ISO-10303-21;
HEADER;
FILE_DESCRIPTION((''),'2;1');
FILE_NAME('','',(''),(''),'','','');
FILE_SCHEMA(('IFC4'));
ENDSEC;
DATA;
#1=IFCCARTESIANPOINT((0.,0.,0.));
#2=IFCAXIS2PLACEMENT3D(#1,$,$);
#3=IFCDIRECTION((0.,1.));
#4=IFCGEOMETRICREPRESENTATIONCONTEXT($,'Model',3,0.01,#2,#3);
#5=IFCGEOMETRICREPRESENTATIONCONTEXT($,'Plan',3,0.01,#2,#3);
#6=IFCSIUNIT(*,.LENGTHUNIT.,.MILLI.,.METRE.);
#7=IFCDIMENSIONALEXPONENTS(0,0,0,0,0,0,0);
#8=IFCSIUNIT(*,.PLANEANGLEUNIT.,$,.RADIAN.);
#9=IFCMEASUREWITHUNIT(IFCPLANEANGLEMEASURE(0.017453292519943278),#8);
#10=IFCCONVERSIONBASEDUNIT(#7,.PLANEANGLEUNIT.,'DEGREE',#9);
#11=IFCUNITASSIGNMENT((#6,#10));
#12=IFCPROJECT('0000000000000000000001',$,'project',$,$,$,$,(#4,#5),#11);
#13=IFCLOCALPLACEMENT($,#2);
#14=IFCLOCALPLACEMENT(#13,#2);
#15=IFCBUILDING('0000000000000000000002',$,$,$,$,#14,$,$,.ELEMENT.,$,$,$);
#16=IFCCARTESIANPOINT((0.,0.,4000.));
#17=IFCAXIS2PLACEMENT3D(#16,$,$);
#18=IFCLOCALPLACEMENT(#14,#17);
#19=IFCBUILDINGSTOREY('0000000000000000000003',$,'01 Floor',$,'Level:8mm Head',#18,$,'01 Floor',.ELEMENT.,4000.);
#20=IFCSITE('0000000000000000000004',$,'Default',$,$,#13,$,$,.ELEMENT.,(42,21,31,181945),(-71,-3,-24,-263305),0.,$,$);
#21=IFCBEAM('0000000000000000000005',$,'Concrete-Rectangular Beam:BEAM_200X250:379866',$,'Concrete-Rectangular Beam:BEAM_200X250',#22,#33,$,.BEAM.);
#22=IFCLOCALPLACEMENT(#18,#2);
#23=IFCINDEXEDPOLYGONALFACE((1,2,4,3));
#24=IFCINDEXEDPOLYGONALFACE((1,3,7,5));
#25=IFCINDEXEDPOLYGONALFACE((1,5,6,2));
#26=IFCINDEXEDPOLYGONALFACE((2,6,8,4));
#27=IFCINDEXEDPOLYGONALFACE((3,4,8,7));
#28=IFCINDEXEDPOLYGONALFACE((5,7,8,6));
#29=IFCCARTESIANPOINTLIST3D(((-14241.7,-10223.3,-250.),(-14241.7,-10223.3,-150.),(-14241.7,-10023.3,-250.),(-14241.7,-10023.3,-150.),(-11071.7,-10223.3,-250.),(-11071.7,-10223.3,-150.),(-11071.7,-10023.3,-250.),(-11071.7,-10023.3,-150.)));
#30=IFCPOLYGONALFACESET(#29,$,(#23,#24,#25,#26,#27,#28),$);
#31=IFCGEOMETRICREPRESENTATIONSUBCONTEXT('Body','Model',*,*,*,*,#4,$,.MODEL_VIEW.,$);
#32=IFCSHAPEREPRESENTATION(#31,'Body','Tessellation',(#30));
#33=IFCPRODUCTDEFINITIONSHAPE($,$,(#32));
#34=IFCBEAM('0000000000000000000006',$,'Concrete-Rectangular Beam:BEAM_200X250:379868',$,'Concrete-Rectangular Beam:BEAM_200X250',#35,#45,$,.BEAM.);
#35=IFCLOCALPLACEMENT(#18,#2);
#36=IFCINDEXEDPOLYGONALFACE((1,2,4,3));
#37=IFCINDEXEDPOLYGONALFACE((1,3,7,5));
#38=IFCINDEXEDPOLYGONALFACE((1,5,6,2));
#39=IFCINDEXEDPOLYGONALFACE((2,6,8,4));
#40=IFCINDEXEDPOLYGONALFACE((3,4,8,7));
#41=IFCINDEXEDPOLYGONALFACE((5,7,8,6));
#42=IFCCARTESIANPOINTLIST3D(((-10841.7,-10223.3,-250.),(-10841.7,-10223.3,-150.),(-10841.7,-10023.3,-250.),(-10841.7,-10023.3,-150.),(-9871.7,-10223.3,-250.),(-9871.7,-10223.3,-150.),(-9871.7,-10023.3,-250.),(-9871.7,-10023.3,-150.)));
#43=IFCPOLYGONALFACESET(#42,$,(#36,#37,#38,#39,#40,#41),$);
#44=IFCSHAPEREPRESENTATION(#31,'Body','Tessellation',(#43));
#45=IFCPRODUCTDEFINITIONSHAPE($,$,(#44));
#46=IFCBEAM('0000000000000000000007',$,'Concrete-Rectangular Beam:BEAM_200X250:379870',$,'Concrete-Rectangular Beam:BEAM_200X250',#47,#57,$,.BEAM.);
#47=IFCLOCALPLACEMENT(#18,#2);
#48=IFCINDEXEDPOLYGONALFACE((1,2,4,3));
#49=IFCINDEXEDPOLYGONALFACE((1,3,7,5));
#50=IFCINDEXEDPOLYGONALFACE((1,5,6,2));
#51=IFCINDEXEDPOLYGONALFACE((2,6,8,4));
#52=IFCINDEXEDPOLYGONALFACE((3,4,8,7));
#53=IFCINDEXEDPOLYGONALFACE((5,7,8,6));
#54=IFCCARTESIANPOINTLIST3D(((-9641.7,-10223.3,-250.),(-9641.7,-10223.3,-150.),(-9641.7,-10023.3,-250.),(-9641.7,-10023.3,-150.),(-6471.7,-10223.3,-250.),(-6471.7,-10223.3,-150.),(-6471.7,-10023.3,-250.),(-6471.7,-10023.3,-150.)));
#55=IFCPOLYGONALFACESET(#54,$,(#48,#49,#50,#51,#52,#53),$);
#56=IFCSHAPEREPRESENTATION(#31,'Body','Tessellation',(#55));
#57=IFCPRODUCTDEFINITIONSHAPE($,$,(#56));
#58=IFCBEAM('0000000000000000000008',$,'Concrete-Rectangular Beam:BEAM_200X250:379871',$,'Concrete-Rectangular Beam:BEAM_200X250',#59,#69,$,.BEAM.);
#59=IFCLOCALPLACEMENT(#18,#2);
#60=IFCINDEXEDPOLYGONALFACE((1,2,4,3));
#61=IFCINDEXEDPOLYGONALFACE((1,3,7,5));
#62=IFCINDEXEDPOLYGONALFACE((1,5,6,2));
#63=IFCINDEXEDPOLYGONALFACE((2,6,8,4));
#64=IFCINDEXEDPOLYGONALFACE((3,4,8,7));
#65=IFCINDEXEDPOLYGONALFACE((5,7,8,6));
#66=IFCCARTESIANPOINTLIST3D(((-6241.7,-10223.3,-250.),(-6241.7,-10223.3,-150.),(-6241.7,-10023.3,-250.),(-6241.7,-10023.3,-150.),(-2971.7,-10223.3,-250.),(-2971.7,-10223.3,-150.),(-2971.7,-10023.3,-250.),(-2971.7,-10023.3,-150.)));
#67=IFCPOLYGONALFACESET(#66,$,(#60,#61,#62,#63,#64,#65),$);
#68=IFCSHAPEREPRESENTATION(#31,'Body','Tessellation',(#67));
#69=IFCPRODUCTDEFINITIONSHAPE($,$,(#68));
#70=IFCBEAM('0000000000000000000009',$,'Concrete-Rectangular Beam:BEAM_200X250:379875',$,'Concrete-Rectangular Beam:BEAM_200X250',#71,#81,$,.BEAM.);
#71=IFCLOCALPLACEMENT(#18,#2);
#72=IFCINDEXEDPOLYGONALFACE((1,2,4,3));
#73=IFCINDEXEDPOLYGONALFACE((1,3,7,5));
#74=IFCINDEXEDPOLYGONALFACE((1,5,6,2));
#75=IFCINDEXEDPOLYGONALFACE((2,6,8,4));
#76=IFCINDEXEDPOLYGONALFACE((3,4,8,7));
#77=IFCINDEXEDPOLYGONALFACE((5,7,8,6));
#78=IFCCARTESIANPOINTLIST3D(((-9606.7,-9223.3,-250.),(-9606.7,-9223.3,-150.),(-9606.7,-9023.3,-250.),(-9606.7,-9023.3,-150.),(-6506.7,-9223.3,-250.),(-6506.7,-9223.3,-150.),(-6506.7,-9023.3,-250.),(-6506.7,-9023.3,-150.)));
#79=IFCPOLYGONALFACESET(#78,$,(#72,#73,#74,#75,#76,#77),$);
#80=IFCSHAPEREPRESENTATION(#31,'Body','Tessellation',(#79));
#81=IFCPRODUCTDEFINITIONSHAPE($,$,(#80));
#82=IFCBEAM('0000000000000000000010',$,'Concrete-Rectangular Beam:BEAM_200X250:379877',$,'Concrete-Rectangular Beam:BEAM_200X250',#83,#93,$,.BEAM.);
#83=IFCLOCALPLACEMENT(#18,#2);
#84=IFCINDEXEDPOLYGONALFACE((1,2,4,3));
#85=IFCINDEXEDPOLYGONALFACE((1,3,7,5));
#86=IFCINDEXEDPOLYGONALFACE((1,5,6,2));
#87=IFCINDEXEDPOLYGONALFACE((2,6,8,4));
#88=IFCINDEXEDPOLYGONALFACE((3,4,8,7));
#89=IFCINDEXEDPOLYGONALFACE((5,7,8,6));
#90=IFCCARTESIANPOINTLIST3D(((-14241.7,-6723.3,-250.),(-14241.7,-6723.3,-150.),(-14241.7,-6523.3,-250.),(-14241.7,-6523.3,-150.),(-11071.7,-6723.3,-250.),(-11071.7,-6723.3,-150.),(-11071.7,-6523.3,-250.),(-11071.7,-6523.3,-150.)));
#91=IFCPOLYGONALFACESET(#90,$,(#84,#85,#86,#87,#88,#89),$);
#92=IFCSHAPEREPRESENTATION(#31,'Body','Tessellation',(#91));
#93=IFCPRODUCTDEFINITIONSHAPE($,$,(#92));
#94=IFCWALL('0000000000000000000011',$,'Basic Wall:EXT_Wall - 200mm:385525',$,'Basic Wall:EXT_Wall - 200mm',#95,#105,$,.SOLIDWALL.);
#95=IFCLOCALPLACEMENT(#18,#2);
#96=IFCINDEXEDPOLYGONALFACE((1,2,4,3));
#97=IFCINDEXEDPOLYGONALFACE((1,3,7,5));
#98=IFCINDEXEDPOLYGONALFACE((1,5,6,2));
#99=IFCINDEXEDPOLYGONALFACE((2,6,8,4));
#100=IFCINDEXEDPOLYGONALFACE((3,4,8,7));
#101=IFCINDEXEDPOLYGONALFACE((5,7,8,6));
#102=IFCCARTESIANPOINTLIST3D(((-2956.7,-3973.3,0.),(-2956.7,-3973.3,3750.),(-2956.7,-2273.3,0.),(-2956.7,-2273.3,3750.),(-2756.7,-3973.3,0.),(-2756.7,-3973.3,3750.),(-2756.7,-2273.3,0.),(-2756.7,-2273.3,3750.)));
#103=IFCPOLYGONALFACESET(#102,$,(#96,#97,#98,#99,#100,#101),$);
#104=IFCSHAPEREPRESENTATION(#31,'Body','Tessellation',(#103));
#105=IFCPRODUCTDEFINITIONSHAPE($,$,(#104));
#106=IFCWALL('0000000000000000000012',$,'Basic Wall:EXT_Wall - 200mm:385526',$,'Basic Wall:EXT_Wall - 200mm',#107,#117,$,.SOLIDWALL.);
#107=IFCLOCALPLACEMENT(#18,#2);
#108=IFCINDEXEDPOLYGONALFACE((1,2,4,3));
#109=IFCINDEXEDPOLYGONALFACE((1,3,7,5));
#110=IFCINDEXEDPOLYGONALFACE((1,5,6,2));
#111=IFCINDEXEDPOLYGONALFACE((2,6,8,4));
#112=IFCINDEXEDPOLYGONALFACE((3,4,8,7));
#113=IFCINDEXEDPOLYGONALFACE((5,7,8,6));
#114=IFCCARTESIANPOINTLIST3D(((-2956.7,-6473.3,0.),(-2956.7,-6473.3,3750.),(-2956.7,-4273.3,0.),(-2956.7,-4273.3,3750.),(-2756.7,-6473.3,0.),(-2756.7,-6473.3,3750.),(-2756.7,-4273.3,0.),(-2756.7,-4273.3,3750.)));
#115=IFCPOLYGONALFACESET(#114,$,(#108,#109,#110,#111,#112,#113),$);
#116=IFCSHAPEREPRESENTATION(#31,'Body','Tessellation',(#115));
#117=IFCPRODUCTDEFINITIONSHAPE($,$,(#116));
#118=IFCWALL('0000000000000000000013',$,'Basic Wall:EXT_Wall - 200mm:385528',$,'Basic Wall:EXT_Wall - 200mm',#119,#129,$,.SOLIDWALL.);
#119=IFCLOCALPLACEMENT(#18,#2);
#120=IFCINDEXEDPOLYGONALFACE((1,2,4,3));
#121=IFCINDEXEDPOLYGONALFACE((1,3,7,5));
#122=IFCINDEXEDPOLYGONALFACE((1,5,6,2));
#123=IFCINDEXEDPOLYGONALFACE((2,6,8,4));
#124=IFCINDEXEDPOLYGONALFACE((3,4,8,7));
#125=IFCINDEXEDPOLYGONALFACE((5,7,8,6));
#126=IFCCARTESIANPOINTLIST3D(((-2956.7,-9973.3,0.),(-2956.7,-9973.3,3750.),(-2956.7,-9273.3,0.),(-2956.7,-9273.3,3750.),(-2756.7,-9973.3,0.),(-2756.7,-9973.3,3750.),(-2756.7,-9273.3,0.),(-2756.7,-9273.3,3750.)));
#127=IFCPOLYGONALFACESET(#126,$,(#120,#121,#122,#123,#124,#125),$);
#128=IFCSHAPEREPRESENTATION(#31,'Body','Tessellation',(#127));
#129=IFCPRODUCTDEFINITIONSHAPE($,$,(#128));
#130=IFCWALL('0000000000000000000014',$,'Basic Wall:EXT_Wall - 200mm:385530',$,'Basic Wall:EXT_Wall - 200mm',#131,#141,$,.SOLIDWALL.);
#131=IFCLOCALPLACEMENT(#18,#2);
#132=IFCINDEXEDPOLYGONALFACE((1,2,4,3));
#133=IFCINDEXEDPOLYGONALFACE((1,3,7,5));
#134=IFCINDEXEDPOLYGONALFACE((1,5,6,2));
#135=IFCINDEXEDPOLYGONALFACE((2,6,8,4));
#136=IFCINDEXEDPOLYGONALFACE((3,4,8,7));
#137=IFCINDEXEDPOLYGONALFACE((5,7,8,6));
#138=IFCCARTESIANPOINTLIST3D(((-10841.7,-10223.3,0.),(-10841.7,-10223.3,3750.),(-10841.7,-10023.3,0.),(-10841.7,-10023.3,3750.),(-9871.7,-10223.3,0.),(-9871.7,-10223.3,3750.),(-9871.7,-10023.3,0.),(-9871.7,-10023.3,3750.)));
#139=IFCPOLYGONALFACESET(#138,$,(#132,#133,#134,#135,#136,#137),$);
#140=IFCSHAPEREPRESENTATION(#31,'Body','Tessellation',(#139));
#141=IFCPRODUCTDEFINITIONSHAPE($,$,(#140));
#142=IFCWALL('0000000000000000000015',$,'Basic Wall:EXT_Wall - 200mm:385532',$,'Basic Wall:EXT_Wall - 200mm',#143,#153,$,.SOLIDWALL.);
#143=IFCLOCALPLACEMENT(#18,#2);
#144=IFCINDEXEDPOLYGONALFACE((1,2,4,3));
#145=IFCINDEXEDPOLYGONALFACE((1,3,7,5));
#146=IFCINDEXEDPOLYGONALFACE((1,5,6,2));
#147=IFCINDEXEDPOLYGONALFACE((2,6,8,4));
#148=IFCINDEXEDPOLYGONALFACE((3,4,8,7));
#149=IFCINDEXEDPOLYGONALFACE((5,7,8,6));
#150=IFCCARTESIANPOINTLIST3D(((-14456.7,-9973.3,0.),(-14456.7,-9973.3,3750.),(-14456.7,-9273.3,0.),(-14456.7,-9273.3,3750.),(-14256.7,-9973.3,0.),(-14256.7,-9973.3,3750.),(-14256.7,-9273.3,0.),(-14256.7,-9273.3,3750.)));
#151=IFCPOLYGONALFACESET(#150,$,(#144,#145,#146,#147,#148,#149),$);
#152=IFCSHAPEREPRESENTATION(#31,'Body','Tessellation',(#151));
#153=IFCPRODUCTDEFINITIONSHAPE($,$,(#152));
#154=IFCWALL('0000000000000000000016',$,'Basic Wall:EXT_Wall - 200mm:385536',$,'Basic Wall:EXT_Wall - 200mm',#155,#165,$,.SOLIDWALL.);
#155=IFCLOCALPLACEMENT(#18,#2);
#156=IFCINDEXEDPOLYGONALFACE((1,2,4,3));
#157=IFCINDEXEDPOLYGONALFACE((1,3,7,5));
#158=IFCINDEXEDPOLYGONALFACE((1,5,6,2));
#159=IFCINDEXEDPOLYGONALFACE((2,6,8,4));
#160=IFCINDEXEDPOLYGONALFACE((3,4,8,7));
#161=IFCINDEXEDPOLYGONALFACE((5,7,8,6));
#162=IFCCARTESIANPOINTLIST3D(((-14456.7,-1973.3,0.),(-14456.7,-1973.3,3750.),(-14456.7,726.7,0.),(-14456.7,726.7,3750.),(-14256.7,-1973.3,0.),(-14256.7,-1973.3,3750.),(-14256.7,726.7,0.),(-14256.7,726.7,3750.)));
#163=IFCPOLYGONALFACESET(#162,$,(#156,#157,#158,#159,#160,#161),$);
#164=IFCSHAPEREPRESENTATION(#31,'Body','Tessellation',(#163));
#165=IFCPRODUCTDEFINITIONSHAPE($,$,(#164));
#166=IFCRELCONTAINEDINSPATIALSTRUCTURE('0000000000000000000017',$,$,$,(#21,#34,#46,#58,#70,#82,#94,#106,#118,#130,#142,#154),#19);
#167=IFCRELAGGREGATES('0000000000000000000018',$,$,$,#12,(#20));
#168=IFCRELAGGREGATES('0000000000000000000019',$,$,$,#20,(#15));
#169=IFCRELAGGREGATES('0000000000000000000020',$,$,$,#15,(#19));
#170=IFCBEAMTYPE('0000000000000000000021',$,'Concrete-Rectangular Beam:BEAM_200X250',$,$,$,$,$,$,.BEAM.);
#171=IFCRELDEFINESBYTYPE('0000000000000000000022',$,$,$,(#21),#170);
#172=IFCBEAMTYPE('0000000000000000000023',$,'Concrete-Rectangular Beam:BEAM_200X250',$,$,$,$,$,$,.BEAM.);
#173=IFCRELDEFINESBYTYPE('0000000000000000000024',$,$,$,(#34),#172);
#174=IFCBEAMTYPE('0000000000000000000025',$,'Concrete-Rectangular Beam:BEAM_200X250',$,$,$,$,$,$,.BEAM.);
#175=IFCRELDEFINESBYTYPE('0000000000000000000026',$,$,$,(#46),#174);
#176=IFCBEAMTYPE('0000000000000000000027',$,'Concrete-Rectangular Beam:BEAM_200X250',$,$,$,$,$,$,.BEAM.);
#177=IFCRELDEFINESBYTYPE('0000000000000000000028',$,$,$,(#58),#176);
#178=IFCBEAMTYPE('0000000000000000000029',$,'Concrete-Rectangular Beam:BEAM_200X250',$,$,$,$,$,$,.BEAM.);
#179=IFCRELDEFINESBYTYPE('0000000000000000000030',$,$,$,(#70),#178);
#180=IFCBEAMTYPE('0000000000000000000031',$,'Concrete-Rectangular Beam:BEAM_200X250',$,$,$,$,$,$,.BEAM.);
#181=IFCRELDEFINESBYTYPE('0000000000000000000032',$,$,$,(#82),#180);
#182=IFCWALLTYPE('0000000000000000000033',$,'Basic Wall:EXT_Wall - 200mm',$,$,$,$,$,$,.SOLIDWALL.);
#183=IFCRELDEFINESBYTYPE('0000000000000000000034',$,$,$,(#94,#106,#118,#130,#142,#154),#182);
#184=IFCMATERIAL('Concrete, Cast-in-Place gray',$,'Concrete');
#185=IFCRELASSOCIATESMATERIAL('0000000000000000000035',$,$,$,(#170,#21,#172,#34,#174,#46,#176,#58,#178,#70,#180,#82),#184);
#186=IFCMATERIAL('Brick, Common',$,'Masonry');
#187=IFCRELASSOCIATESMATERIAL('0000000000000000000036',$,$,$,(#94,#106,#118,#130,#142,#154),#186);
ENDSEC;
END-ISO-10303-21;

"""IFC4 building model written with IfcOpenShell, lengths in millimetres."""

from ifc_helpers import new_model, entity, si_unit, converted_unit, direction, frame, origin, place, context, subcontext, project, spatial, indexed_curve, outline, extrude, source, transform, mapped, material, type_object, type_shapes, element, save


model = new_model("IFC4")

# Units and contexts
model_context = context("Model", 3, precision=0.01, world=origin(), true_north=direction((0.0, 1.0)))
plan_context = context("Plan", 3, precision=0.01, world=origin(), true_north=direction((0.0, 1.0)))
body_context = subcontext(model_context, "Body", "Model", "MODEL_VIEW")
ifc_project = project(units=[si_unit("LENGTHUNIT", "METRE", prefix="MILLI"), converted_unit("PLANEANGLEUNIT", "DEGREE", entity("IfcPlaneAngleMeasure", 0.017453292519943278), si_unit("PLANEANGLEUNIT", "RADIAN"), dimensions=[0, 0, 0, 0, 0, 0, 0])], contexts=[model_context, plan_context])

# Site, building, storey
site_placement = place(None, origin())
site = spatial("IfcSite", under=ifc_project, at=site_placement, Name="Default", CompositionType="ELEMENT", RefLatitude=(42, 21, 31, 181945), RefLongitude=(-71, -3, -24, -263305), RefElevation=0.0)
building_placement = place(site_placement, origin())
building = spatial("IfcBuilding", under=site, at=building_placement, CompositionType="ELEMENT")
storey_placement = place(building_placement, frame((0.0, 0.0, 4000.0)))
storey = spatial("IfcBuildingStorey", under=building, at=storey_placement, Name="01 Floor", ObjectType="Level:8mm Head", LongName="01 Floor", CompositionType="ELEMENT", Elevation=4000.0)

# Beams
ifc_material_1 = material(Name="Concrete, Cast-in-Place gray", Category="Concrete")
beam_type_1 = type_object("IfcBeamType", Name="Concrete-Rectangular Beam:BEAM_200X250", PredefinedType="BEAM", material=ifc_material_1)
shared_shape_1 = source(origin(), body_context, "Body", "SweptSolid", [
    extrude(outline(indexed_curve([(-50.0, -100.0), (50.0, -100.0), (50.0, 100.0), (-50.0, 100.0), (-50.0, -100.0)], self_intersect=False)), frame((-14241.7, -10123.3, 3800.0), z_axis=(1.0, 0.0, 0.0), x_axis=(0.0, 0.0, -1.0)), (0.0, 0.0, 1.0), 3170.0),
])
type_shapes(beam_type_1, [shared_shape_1])
beam_1_placement = place(storey_placement, frame((0.0, 0.0, -4000.0)))
element("IfcBeam", 1, at=beam_1_placement, inside=storey, type_object=beam_type_1, material=ifc_material_1, Name="Concrete-Rectangular Beam:BEAM_200X250:379866", ObjectType="Concrete-Rectangular Beam:BEAM_200X250", PredefinedType="BEAM", context=body_context, shape_type="MappedRepresentation", body=[
    mapped(shared_shape_1, transform((0.0, 0.0, 0.0), scale=1.0)),
])
beam_type_2 = type_object("IfcBeamType", Name="Concrete-Rectangular Beam:BEAM_200X250", PredefinedType="BEAM", material=ifc_material_1)
shared_shape_2 = source(origin(), body_context, "Body", "SweptSolid", [
    extrude(outline(indexed_curve([(-50.0, -100.0), (50.0, -100.0), (50.0, 100.0), (-50.0, 100.0), (-50.0, -100.0)], self_intersect=False)), frame((-10841.7, -10123.3, 3800.0), z_axis=(1.0, 0.0, 0.0), x_axis=(0.0, 0.0, -1.0)), (0.0, 0.0, 1.0), 970.0),
])
type_shapes(beam_type_2, [shared_shape_2])
beam_2_placement = place(storey_placement, frame((0.0, 0.0, -4000.0)))
element("IfcBeam", 2, at=beam_2_placement, inside=storey, type_object=beam_type_2, material=ifc_material_1, Name="Concrete-Rectangular Beam:BEAM_200X250:379868", ObjectType="Concrete-Rectangular Beam:BEAM_200X250", PredefinedType="BEAM", context=body_context, shape_type="MappedRepresentation", body=[
    mapped(shared_shape_2, transform((0.0, 0.0, 0.0), scale=1.0)),
])
beam_type_3 = type_object("IfcBeamType", Name="Concrete-Rectangular Beam:BEAM_200X250", PredefinedType="BEAM", material=ifc_material_1)
shared_shape_3 = source(origin(), body_context, "Body", "SweptSolid", [
    extrude(outline(indexed_curve([(-50.0, -100.0), (50.0, -100.0), (50.0, 100.0), (-50.0, 100.0), (-50.0, -100.0)], self_intersect=False)), frame((-9641.7, -10123.3, 3800.0), z_axis=(1.0, 0.0, 0.0), x_axis=(0.0, 0.0, -1.0)), (0.0, 0.0, 1.0), 3170.0),
])
type_shapes(beam_type_3, [shared_shape_3])
beam_3_placement = place(storey_placement, frame((0.0, 0.0, -4000.0)))
element("IfcBeam", 3, at=beam_3_placement, inside=storey, type_object=beam_type_3, material=ifc_material_1, Name="Concrete-Rectangular Beam:BEAM_200X250:379870", ObjectType="Concrete-Rectangular Beam:BEAM_200X250", PredefinedType="BEAM", context=body_context, shape_type="MappedRepresentation", body=[
    mapped(shared_shape_3, transform((0.0, 0.0, 0.0), scale=1.0)),
])
beam_type_4 = type_object("IfcBeamType", Name="Concrete-Rectangular Beam:BEAM_200X250", PredefinedType="BEAM", material=ifc_material_1)
shared_shape_4 = source(origin(), body_context, "Body", "SweptSolid", [
    extrude(outline(indexed_curve([(-50.0, -100.0), (50.0, -100.0), (50.0, 100.0), (-50.0, 100.0), (-50.0, -100.0)], self_intersect=False)), frame((-6241.7, -10123.3, 3800.0), z_axis=(1.0, 0.0, 0.0), x_axis=(0.0, 0.0, -1.0)), (0.0, 0.0, 1.0), 3270.0),
])
type_shapes(beam_type_4, [shared_shape_4])
beam_4_placement = place(storey_placement, frame((0.0, 0.0, -4000.0)))
element("IfcBeam", 4, at=beam_4_placement, inside=storey, type_object=beam_type_4, material=ifc_material_1, Name="Concrete-Rectangular Beam:BEAM_200X250:379871", ObjectType="Concrete-Rectangular Beam:BEAM_200X250", PredefinedType="BEAM", context=body_context, shape_type="MappedRepresentation", body=[
    mapped(shared_shape_4, transform((0.0, 0.0, 0.0), scale=1.0)),
])
beam_type_5 = type_object("IfcBeamType", Name="Concrete-Rectangular Beam:BEAM_200X250", PredefinedType="BEAM", material=ifc_material_1)
shared_shape_5 = source(origin(), body_context, "Body", "SweptSolid", [
    extrude(outline(indexed_curve([(-50.0, -100.0), (50.0, -100.0), (50.0, 100.0), (-50.0, 100.0), (-50.0, -100.0)], self_intersect=False)), frame((-9606.7, -9123.3, 3800.0), z_axis=(1.0, 0.0, 0.0), x_axis=(0.0, 0.0, -1.0)), (0.0, 0.0, 1.0), 3100.0),
])
type_shapes(beam_type_5, [shared_shape_5])
beam_5_placement = place(storey_placement, frame((0.0, 0.0, -4000.0)))
element("IfcBeam", 5, at=beam_5_placement, inside=storey, type_object=beam_type_5, material=ifc_material_1, Name="Concrete-Rectangular Beam:BEAM_200X250:379875", ObjectType="Concrete-Rectangular Beam:BEAM_200X250", PredefinedType="BEAM", context=body_context, shape_type="MappedRepresentation", body=[
    mapped(shared_shape_5, transform((0.0, 0.0, 0.0), scale=1.0)),
])
beam_type_6 = type_object("IfcBeamType", Name="Concrete-Rectangular Beam:BEAM_200X250", PredefinedType="BEAM", material=ifc_material_1)
shared_shape_6 = source(origin(), body_context, "Body", "SweptSolid", [
    extrude(outline(indexed_curve([(-50.0, -100.0), (50.0, -100.0), (50.0, 100.0), (-50.0, 100.0), (-50.0, -100.0)], self_intersect=False)), frame((-14241.7, -6623.3, 3800.0), z_axis=(1.0, 0.0, 0.0), x_axis=(0.0, 0.0, -1.0)), (0.0, 0.0, 1.0), 3170.0),
])
type_shapes(beam_type_6, [shared_shape_6])
beam_6_placement = place(storey_placement, frame((0.0, 0.0, -4000.0)))
element("IfcBeam", 6, at=beam_6_placement, inside=storey, type_object=beam_type_6, material=ifc_material_1, Name="Concrete-Rectangular Beam:BEAM_200X250:379877", ObjectType="Concrete-Rectangular Beam:BEAM_200X250", PredefinedType="BEAM", context=body_context, shape_type="MappedRepresentation", body=[
    mapped(shared_shape_6, transform((0.0, 0.0, 0.0), scale=1.0)),
])

# Walls
ifc_material_2 = material(Name="Brick, Common", Category="Masonry")
wall_type_1 = type_object("IfcWallType", Name="Basic Wall:EXT_Wall - 200mm", PredefinedType="SOLIDWALL")
wall_1_placement = place(storey_placement, frame((-2856.7, -2273.3, 0.0), z_axis=(0.0, 0.0, 1.0), x_axis=(0.0, -1.0, 0.0)))
element("IfcWall", 7, at=wall_1_placement, inside=storey, type_object=wall_type_1, material=ifc_material_2, Name="Basic Wall:EXT_Wall - 200mm:385525", ObjectType="Basic Wall:EXT_Wall - 200mm", PredefinedType="SOLIDWALL", context=body_context, shape_type="SweptSolid", body=[
    extrude(outline(indexed_curve([(1700.0, 100.0), (0.0, 100.0), (0.0, -100.0), (1700.0, -100.0), (1700.0, 100.0)], self_intersect=False)), origin(), (0.0, 0.0, 1.0), 3750.0),
])
wall_2_placement = place(storey_placement, frame((-2856.7, -4273.3, 0.0), z_axis=(0.0, 0.0, 1.0), x_axis=(0.0, -1.0, 0.0)))
element("IfcWall", 8, at=wall_2_placement, inside=storey, type_object=wall_type_1, material=ifc_material_2, Name="Basic Wall:EXT_Wall - 200mm:385526", ObjectType="Basic Wall:EXT_Wall - 200mm", PredefinedType="SOLIDWALL", context=body_context, shape_type="SweptSolid", body=[
    extrude(outline(indexed_curve([(2200.0, 100.0), (0.0, 100.0), (0.0, -100.0), (2200.0, -100.0), (2200.0, 100.0)], self_intersect=False)), origin(), (0.0, 0.0, 1.0), 3750.0),
])
wall_3_placement = place(storey_placement, frame((-2856.7, -9273.3, 0.0), z_axis=(0.0, 0.0, 1.0), x_axis=(0.0, -1.0, 0.0)))
element("IfcWall", 9, at=wall_3_placement, inside=storey, type_object=wall_type_1, material=ifc_material_2, Name="Basic Wall:EXT_Wall - 200mm:385528", ObjectType="Basic Wall:EXT_Wall - 200mm", PredefinedType="SOLIDWALL", context=body_context, shape_type="SweptSolid", body=[
    extrude(outline(indexed_curve([(700.0, 100.0), (0.0, 100.0), (0.0, -100.0), (700.0, -100.0), (700.0, 100.0)], self_intersect=False)), origin(), (0.0, 0.0, 1.0), 3750.0),
])
wall_4_placement = place(storey_placement, frame((-9871.7, -10123.3, 0.0), z_axis=(0.0, 0.0, 1.0), x_axis=(-1.0, 0.0, 0.0)))
element("IfcWall", 10, at=wall_4_placement, inside=storey, type_object=wall_type_1, material=ifc_material_2, Name="Basic Wall:EXT_Wall - 200mm:385530", ObjectType="Basic Wall:EXT_Wall - 200mm", PredefinedType="SOLIDWALL", context=body_context, shape_type="SweptSolid", body=[
    extrude(outline(indexed_curve([(970.0, 100.0), (0.0, 100.0), (0.0, -100.0), (970.0, -100.0), (970.0, 100.0)], self_intersect=False)), origin(), (0.0, 0.0, 1.0), 3750.0),
])
wall_5_placement = place(storey_placement, frame((-14356.7, -9973.3, 0.0), z_axis=(0.0, 0.0, 1.0), x_axis=(0.0, 1.0, 0.0)))
element("IfcWall", 11, at=wall_5_placement, inside=storey, type_object=wall_type_1, material=ifc_material_2, Name="Basic Wall:EXT_Wall - 200mm:385532", ObjectType="Basic Wall:EXT_Wall - 200mm", PredefinedType="SOLIDWALL", context=body_context, shape_type="SweptSolid", body=[
    extrude(outline(indexed_curve([(700.0, 100.0), (0.0, 100.0), (0.0, -100.0), (700.0, -100.0), (700.0, 100.0)], self_intersect=False)), origin(), (0.0, 0.0, 1.0), 3750.0),
])
wall_6_placement = place(storey_placement, frame((-14356.7, -1973.3, 0.0), z_axis=(0.0, 0.0, 1.0), x_axis=(0.0, 1.0, 0.0)))
element("IfcWall", 12, at=wall_6_placement, inside=storey, type_object=wall_type_1, material=ifc_material_2, Name="Basic Wall:EXT_Wall - 200mm:385536", ObjectType="Basic Wall:EXT_Wall - 200mm", PredefinedType="SOLIDWALL", context=body_context, shape_type="SweptSolid", body=[
    extrude(outline(indexed_curve([(2700.0, 100.0), (0.0, 100.0), (0.0, -100.0), (2700.0, -100.0), (2700.0, 100.0)], self_intersect=False)), origin(), (0.0, 0.0, 1.0), 3750.0),
])

save(model, "model.ifc")
